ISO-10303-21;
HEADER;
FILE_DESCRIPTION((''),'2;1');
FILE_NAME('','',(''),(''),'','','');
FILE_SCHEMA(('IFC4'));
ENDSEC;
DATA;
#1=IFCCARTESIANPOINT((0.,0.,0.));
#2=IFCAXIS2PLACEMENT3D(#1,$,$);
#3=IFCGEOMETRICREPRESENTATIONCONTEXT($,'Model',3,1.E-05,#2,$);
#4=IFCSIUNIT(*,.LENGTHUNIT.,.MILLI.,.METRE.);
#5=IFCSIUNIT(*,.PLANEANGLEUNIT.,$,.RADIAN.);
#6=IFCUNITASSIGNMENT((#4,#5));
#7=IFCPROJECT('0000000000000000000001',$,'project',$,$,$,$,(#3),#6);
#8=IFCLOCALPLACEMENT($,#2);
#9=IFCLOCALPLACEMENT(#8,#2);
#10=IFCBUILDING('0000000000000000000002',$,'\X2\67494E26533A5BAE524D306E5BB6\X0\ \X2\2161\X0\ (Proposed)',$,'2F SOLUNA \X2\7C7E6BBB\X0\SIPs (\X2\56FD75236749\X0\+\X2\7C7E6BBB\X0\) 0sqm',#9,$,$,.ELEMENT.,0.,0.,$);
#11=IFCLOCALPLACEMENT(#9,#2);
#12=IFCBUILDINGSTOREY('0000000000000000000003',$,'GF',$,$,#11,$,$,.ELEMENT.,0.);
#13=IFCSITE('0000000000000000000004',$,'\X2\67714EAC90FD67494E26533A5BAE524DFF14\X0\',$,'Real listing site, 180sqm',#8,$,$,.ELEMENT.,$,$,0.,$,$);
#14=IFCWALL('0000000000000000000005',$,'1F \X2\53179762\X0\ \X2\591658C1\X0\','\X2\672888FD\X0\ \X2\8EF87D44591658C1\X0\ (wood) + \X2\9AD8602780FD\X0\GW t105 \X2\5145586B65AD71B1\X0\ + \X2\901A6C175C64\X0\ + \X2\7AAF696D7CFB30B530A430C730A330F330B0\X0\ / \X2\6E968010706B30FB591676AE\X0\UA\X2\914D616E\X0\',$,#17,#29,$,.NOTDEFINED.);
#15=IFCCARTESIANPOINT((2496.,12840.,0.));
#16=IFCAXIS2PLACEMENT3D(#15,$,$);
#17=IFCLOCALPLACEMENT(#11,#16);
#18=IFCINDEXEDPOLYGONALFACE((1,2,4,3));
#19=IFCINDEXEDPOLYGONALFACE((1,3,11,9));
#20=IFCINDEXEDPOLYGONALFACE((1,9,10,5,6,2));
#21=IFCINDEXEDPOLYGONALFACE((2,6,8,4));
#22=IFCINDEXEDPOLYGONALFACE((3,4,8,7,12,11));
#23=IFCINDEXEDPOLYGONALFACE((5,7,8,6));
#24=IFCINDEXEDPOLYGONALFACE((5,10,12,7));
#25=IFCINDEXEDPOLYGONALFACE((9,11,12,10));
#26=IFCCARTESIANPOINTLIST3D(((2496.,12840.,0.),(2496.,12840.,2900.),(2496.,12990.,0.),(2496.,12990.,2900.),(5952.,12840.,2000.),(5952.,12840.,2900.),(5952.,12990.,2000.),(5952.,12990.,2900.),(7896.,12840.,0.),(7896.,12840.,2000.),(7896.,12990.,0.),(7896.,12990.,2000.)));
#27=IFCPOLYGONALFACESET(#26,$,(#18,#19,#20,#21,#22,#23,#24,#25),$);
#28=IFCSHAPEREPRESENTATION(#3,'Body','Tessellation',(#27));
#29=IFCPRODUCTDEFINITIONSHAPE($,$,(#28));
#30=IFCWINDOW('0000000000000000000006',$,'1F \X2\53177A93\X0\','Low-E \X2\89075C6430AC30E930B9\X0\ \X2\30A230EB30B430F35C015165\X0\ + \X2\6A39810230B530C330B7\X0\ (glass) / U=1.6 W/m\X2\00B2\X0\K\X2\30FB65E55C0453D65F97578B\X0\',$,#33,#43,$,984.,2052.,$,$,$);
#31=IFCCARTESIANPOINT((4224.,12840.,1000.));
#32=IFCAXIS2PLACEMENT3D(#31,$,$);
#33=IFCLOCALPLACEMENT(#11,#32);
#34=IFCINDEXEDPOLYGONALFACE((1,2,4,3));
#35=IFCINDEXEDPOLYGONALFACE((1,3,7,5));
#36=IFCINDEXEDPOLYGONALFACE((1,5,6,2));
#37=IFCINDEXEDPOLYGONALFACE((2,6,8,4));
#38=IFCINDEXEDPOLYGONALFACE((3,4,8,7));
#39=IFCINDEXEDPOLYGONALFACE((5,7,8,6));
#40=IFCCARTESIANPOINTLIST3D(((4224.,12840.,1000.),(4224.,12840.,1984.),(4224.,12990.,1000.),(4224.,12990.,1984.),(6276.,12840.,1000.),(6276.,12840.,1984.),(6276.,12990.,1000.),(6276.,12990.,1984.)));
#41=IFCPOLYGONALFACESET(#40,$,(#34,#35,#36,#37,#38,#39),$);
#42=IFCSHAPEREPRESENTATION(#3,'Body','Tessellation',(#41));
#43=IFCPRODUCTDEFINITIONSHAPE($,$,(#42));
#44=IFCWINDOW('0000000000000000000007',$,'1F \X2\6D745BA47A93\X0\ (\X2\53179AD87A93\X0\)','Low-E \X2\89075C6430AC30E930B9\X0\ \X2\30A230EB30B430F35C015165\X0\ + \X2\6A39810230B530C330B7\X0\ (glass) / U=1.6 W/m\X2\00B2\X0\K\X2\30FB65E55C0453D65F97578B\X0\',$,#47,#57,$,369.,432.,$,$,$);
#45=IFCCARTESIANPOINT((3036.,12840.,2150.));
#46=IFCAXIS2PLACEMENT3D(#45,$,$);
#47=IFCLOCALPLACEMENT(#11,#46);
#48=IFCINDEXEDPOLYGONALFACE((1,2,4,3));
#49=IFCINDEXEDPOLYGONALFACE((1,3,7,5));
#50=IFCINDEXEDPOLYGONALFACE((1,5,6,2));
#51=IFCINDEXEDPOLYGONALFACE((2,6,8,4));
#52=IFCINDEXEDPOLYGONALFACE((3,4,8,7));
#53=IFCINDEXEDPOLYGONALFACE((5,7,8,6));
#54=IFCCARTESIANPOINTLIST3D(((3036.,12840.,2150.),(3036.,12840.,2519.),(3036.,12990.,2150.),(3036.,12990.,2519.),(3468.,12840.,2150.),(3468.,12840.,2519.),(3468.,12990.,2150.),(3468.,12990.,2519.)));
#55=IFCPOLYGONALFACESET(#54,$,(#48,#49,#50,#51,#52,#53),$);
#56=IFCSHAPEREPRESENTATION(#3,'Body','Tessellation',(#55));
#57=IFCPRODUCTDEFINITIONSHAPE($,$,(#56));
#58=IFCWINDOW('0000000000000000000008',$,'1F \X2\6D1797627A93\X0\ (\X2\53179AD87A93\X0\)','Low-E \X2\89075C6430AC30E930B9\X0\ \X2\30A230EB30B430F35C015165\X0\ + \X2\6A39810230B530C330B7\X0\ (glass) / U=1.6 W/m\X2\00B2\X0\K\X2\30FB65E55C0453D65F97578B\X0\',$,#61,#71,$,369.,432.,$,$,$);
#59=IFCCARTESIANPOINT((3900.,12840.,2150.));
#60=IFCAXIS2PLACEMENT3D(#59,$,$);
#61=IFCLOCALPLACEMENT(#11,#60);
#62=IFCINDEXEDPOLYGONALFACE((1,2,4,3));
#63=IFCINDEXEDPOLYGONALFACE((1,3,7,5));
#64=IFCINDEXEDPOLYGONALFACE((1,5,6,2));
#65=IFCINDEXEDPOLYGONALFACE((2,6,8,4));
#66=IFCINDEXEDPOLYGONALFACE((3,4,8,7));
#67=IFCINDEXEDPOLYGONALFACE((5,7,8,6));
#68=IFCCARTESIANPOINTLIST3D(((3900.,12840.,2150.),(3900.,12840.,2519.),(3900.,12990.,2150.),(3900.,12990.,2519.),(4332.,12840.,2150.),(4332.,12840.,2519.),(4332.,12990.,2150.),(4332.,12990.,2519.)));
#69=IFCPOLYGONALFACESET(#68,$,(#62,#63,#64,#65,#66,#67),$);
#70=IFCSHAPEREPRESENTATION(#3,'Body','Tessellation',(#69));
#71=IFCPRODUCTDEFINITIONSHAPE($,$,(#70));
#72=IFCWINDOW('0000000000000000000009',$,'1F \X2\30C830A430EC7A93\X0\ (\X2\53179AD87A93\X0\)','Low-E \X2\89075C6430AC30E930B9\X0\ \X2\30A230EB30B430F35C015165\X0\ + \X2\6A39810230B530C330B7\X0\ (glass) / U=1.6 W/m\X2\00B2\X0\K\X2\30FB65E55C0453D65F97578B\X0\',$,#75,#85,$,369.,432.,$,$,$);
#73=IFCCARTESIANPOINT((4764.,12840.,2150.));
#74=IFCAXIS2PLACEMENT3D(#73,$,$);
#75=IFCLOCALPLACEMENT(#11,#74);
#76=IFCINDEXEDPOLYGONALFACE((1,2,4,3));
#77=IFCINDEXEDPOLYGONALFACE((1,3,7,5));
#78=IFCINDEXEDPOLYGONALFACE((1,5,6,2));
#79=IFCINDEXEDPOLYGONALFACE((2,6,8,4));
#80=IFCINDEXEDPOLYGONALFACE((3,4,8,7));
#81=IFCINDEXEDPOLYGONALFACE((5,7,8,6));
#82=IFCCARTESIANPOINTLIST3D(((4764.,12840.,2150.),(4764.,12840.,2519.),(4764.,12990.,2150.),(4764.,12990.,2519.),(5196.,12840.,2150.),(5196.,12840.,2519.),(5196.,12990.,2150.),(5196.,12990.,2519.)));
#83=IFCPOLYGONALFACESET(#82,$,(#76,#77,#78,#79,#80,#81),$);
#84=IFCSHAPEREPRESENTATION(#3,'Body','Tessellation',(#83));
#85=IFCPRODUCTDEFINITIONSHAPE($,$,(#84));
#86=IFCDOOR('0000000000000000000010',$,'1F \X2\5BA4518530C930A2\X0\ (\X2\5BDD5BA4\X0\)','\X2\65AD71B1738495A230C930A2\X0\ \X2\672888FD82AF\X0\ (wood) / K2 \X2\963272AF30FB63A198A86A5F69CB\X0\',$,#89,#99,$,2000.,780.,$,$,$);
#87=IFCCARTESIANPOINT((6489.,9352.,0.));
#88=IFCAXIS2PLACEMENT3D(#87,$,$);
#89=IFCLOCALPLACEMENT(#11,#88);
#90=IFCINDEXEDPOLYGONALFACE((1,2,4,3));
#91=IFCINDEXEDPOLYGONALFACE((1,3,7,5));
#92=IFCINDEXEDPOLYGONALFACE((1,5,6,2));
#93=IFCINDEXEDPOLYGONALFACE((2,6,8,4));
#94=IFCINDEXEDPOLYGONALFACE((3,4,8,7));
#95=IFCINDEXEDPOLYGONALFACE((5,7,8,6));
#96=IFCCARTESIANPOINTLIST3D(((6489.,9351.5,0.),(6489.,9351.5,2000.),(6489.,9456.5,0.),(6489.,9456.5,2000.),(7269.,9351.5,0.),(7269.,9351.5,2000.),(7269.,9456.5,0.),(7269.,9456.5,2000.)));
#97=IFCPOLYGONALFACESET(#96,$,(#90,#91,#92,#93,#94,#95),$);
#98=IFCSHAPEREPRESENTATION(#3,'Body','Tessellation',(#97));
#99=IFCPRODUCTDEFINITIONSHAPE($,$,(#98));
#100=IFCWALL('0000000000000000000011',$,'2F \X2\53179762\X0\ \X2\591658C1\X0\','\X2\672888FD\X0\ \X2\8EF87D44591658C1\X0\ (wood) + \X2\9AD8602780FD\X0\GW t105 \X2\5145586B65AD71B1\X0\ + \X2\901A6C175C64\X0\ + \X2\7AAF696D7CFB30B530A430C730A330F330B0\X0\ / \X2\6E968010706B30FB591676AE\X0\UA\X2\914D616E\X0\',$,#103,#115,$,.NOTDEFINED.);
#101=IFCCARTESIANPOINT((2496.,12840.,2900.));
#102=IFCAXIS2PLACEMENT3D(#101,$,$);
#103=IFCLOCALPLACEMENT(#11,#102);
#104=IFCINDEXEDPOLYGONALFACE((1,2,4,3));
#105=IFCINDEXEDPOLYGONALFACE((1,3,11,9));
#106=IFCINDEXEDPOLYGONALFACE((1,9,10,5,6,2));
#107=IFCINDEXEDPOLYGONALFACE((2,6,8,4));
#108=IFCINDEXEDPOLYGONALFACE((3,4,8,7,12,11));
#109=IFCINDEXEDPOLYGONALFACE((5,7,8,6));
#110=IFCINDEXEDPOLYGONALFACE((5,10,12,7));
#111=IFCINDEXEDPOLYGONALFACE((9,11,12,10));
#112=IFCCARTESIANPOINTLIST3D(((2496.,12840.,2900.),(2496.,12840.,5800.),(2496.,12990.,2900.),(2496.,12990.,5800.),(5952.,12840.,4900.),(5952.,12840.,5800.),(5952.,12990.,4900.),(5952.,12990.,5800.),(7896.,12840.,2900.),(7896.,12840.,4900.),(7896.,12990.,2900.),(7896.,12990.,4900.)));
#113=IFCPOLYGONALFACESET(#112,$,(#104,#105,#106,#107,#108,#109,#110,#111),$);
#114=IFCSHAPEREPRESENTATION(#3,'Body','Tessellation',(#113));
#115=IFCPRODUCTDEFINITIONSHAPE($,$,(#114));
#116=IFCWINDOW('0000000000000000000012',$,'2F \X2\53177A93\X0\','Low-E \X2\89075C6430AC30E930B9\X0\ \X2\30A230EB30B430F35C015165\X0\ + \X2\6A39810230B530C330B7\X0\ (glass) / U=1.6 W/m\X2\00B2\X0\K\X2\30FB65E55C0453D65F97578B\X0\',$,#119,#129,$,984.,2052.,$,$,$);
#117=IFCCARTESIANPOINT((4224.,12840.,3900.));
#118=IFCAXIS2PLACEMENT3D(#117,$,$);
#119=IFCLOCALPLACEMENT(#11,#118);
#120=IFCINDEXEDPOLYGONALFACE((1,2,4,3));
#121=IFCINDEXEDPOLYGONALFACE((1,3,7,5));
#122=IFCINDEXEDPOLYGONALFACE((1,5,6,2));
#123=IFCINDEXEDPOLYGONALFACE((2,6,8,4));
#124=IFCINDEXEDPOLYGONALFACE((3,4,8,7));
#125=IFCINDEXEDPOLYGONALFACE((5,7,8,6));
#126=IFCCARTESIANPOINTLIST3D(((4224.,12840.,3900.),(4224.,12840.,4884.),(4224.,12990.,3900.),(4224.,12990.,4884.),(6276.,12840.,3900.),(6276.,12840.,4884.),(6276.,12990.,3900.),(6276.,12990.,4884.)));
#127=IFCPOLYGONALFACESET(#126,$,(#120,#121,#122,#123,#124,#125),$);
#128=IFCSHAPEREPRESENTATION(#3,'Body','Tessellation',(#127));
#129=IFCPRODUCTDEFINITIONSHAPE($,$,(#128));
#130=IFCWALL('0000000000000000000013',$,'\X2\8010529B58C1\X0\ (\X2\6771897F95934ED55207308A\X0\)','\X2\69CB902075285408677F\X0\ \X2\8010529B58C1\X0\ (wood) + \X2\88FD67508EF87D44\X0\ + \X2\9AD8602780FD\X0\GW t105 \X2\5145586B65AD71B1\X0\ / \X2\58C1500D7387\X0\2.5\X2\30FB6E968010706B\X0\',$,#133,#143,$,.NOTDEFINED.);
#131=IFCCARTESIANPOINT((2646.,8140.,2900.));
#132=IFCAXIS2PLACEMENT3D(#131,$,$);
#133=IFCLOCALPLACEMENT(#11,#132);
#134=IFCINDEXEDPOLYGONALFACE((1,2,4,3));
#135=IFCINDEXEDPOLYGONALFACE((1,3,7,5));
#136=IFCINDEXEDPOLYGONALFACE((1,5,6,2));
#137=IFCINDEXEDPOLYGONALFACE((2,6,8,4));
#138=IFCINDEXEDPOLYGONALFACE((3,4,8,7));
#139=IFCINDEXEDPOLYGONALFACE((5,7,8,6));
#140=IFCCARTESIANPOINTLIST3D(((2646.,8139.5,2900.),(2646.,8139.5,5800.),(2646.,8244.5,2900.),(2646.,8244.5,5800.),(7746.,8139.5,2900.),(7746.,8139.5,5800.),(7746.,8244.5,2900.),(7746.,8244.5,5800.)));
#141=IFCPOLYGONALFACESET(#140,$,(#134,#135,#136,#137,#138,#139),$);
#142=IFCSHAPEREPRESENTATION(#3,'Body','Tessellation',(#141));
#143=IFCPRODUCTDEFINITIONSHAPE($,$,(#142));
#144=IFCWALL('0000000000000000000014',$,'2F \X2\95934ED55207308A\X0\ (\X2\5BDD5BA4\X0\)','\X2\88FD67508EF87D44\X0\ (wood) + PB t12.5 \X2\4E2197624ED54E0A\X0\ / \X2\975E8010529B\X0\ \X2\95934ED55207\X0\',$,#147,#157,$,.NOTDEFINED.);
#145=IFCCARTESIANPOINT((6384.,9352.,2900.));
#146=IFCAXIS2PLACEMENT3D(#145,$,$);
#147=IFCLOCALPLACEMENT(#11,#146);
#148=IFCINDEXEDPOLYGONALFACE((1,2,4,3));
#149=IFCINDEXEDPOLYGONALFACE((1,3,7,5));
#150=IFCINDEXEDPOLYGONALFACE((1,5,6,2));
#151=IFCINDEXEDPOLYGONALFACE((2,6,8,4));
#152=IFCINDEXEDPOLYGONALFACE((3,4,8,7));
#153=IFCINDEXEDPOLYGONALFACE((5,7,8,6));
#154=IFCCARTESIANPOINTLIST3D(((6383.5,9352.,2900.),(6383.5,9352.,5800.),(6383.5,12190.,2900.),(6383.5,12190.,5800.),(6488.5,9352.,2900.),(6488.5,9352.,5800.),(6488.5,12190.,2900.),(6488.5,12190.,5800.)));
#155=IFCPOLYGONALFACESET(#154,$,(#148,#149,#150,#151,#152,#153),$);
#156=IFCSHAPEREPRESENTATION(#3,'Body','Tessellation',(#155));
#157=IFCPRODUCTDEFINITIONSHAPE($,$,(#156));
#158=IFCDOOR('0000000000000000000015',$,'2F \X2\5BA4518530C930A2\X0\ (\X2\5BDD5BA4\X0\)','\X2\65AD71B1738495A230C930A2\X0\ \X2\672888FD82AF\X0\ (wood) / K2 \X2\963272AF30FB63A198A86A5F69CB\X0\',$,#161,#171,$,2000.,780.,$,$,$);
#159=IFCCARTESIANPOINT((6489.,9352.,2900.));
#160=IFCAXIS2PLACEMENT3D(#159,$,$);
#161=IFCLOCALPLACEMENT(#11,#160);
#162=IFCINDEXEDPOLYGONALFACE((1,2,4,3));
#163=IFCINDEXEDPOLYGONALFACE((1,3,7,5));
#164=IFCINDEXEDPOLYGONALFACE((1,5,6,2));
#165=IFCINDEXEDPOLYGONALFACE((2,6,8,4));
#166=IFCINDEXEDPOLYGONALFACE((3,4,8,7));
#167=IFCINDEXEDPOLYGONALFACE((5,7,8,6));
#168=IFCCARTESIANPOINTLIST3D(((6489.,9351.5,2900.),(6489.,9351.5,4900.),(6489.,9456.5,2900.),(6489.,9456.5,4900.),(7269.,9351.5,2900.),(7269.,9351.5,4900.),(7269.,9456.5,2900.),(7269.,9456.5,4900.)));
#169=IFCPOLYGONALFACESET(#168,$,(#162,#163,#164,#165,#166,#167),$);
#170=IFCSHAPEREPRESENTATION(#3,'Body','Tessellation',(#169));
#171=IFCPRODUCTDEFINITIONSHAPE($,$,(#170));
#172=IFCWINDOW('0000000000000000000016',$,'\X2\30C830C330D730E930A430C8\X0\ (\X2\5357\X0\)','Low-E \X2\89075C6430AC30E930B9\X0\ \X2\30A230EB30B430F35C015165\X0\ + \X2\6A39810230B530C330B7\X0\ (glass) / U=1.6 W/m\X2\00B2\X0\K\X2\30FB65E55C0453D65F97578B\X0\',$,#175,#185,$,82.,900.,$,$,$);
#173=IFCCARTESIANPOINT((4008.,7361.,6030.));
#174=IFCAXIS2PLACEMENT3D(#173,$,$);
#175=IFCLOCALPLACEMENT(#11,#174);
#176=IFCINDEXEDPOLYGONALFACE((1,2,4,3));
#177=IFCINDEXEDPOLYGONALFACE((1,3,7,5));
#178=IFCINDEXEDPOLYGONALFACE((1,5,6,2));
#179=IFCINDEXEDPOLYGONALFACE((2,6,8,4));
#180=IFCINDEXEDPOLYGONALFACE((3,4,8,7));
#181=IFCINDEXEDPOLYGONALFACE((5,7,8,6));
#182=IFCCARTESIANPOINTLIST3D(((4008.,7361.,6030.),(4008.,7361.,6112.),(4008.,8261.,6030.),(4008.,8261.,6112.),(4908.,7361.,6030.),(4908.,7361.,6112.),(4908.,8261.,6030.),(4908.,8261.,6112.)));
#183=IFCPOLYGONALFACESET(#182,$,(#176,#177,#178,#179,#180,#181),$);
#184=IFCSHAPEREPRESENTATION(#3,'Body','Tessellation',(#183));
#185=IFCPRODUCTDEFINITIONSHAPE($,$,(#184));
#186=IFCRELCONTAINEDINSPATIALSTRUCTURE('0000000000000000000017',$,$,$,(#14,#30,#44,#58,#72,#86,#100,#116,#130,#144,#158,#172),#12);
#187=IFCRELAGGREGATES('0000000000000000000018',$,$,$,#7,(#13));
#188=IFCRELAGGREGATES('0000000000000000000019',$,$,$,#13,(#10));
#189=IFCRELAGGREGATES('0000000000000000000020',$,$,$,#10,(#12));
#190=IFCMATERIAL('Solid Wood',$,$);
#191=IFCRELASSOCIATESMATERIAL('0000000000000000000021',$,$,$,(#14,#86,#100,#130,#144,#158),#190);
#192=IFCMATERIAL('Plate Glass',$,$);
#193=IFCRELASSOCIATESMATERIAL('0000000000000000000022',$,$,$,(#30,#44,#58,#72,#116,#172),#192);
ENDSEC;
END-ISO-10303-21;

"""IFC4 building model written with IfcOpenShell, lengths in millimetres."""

from ifc_helpers import new_model, si_unit, frame, frame_2d, origin, place, context, project, spatial, rectangle, extrude, material, element, fill, save


model = new_model("IFC4")

# Units and contexts
model_context = context("Model", 3, precision=1e-05, world=origin())
ifc_project = project(units=[si_unit("LENGTHUNIT", "METRE", prefix="MILLI"), si_unit("PLANEANGLEUNIT", "RADIAN")], contexts=[model_context])

# Site, building, storey
site_placement = place(None, origin())
site = spatial("IfcSite", under=ifc_project, at=site_placement, Name="東京都杉並区宮前４", ObjectType="Real listing site, 180sqm", CompositionType="ELEMENT", RefElevation=0.0)
building_placement = place(site_placement, origin())
building = spatial("IfcBuilding", under=site, at=building_placement, Name="杉並区宮前の家 Ⅱ (Proposed)", ObjectType="2F SOLUNA 籾殻SIPs (国産杉+籾殻) 0sqm", CompositionType="ELEMENT", ElevationOfRefHeight=0.0, ElevationOfTerrain=0.0)
storey_placement = place(building_placement, origin())
storey = spatial("IfcBuildingStorey", under=building, at=storey_placement, Name="GF", CompositionType="ELEMENT", Elevation=0.0)

# Wall, openings, windows
ifc_material_1 = material(Name="Solid Wood")
wall_1_placement = place(storey_placement, frame((2496.0, 12840.0, 0.0)))
wall_1 = element("IfcWall", 1, at=wall_1_placement, inside=storey, material=ifc_material_1, Name="1F 北面 外壁", Description="木製 軸組外壁 (wood) + 高性能GW t105 充填断熱 + 通気層 + 窯業系サイディング / 準耐火・外皮UA配慮", PredefinedType="NOTDEFINED", context=model_context, shape_type="SweptSolid", body=[
    extrude(rectangle(XDim=5400.0, YDim=150.0, at=frame_2d((2700.0, 75.0))), frame((2496.0, 12840.0, 0.0)), (0.0, 0.0, 1.0), 2900.0),
])
opening_1_placement = place(storey_placement, frame((4224.0, 12840.0, 1000.0)))
opening_1 = element("IfcOpeningElement", 2, at=opening_1_placement, cuts=wall_1, PredefinedType="NOTDEFINED", context=model_context, shape_type="SweptSolid", body=[
    extrude(rectangle(XDim=2052.0, YDim=150.0, at=frame_2d((1026.0, 75.0))), frame((4224.0, 12840.0, 1000.0)), (0.0, 0.0, 1.0), 984.0),
])
opening_2_placement = place(storey_placement, frame((3036.0, 12840.0, 2150.0)))
opening_2 = element("IfcOpeningElement", 3, at=opening_2_placement, cuts=wall_1, PredefinedType="NOTDEFINED", context=model_context, shape_type="SweptSolid", body=[
    extrude(rectangle(XDim=432.0, YDim=150.0, at=frame_2d((216.0, 75.0))), frame((3036.0, 12840.0, 2150.0)), (0.0, 0.0, 1.0), 369.0),
])
opening_3_placement = place(storey_placement, frame((3900.0, 12840.0, 2150.0)))
opening_3 = element("IfcOpeningElement", 4, at=opening_3_placement, cuts=wall_1, PredefinedType="NOTDEFINED", context=model_context, shape_type="SweptSolid", body=[
    extrude(rectangle(XDim=432.0, YDim=150.0, at=frame_2d((216.0, 75.0))), frame((3900.0, 12840.0, 2150.0)), (0.0, 0.0, 1.0), 369.0),
])
opening_4_placement = place(storey_placement, frame((4764.0, 12840.0, 2150.0)))
opening_4 = element("IfcOpeningElement", 5, at=opening_4_placement, cuts=wall_1, PredefinedType="NOTDEFINED", context=model_context, shape_type="SweptSolid", body=[
    extrude(rectangle(XDim=432.0, YDim=150.0, at=frame_2d((216.0, 75.0))), frame((4764.0, 12840.0, 2150.0)), (0.0, 0.0, 1.0), 369.0),
])
ifc_material_2 = material(Name="Plate Glass")
window_1_placement = place(storey_placement, frame((4224.0, 12840.0, 1000.0)))
window_1 = element("IfcWindow", 6, at=window_1_placement, inside=storey, material=ifc_material_2, Name="1F 北窓", Description="Low-E 複層ガラス アルゴン封入 + 樹脂サッシ (glass) / U=1.6 W/m²K・日射取得型", OverallHeight=984.0, OverallWidth=2052.0, context=model_context, shape_type="SweptSolid", body=[
    extrude(rectangle(XDim=2052.0, YDim=150.0, at=frame_2d((1026.0, 75.0))), frame((4224.0, 12840.0, 1000.0)), (0.0, 0.0, 1.0), 984.0),
])
fill(opening_1, window_1)
window_2_placement = place(storey_placement, frame((3036.0, 12840.0, 2150.0)))
window_2 = element("IfcWindow", 7, at=window_2_placement, inside=storey, material=ifc_material_2, Name="1F 浴室窓 (北高窓)", Description="Low-E 複層ガラス アルゴン封入 + 樹脂サッシ (glass) / U=1.6 W/m²K・日射取得型", OverallHeight=369.0, OverallWidth=432.0, context=model_context, shape_type="SweptSolid", body=[
    extrude(rectangle(XDim=432.0, YDim=150.0, at=frame_2d((216.0, 75.0))), frame((3036.0, 12840.0, 2150.0)), (0.0, 0.0, 1.0), 369.0),
])
fill(opening_2, window_2)
window_3_placement = place(storey_placement, frame((3900.0, 12840.0, 2150.0)))
window_3 = element("IfcWindow", 8, at=window_3_placement, inside=storey, material=ifc_material_2, Name="1F 洗面窓 (北高窓)", Description="Low-E 複層ガラス アルゴン封入 + 樹脂サッシ (glass) / U=1.6 W/m²K・日射取得型", OverallHeight=369.0, OverallWidth=432.0, context=model_context, shape_type="SweptSolid", body=[
    extrude(rectangle(XDim=432.0, YDim=150.0, at=frame_2d((216.0, 75.0))), frame((3900.0, 12840.0, 2150.0)), (0.0, 0.0, 1.0), 369.0),
])
fill(opening_3, window_3)
window_4_placement = place(storey_placement, frame((4764.0, 12840.0, 2150.0)))
window_4 = element("IfcWindow", 9, at=window_4_placement, inside=storey, material=ifc_material_2, Name="1F トイレ窓 (北高窓)", Description="Low-E 複層ガラス アルゴン封入 + 樹脂サッシ (glass) / U=1.6 W/m²K・日射取得型", OverallHeight=369.0, OverallWidth=432.0, context=model_context, shape_type="SweptSolid", body=[
    extrude(rectangle(XDim=432.0, YDim=150.0, at=frame_2d((216.0, 75.0))), frame((4764.0, 12840.0, 2150.0)), (0.0, 0.0, 1.0), 369.0),
])
fill(opening_4, window_4)

# Door
door_1_placement = place(storey_placement, frame((6489.0, 9352.0, 0.0)))
element("IfcDoor", 10, at=door_1_placement, inside=storey, material=ifc_material_1, Name="1F 室内ドア (寝室)", Description="断熱玄関ドア 木製芯 (wood) / K2 防犯・採風機構", OverallHeight=2000.0, OverallWidth=780.0, context=model_context, shape_type="SweptSolid", body=[
    extrude(rectangle(XDim=780.0, YDim=105.0, at=frame_2d((390.0, 52.0))), frame((6489.0, 9352.0, 0.0)), (0.0, 0.0, 1.0), 2000.0),
])

# Wall, opening, window
wall_2_placement = place(storey_placement, frame((2496.0, 12840.0, 2900.0)))
wall_2 = element("IfcWall", 11, at=wall_2_placement, inside=storey, material=ifc_material_1, Name="2F 北面 外壁", Description="木製 軸組外壁 (wood) + 高性能GW t105 充填断熱 + 通気層 + 窯業系サイディング / 準耐火・外皮UA配慮", PredefinedType="NOTDEFINED", context=model_context, shape_type="SweptSolid", body=[
    extrude(rectangle(XDim=5400.0, YDim=150.0, at=frame_2d((2700.0, 75.0))), frame((2496.0, 12840.0, 2900.0)), (0.0, 0.0, 1.0), 2900.0),
])
opening_5_placement = place(storey_placement, frame((4224.0, 12840.0, 3900.0)))
opening_5 = element("IfcOpeningElement", 12, at=opening_5_placement, cuts=wall_2, PredefinedType="NOTDEFINED", context=model_context, shape_type="SweptSolid", body=[
    extrude(rectangle(XDim=2052.0, YDim=150.0, at=frame_2d((1026.0, 75.0))), frame((4224.0, 12840.0, 3900.0)), (0.0, 0.0, 1.0), 984.0),
])
window_5_placement = place(storey_placement, frame((4224.0, 12840.0, 3900.0)))
window_5 = element("IfcWindow", 13, at=window_5_placement, inside=storey, material=ifc_material_2, Name="2F 北窓", Description="Low-E 複層ガラス アルゴン封入 + 樹脂サッシ (glass) / U=1.6 W/m²K・日射取得型", OverallHeight=984.0, OverallWidth=2052.0, context=model_context, shape_type="SweptSolid", body=[
    extrude(rectangle(XDim=2052.0, YDim=150.0, at=frame_2d((1026.0, 75.0))), frame((4224.0, 12840.0, 3900.0)), (0.0, 0.0, 1.0), 984.0),
])
fill(opening_5, window_5)

# Walls
wall_3_placement = place(storey_placement, frame((2646.0, 8140.0, 2900.0)))
element("IfcWall", 14, at=wall_3_placement, inside=storey, material=ifc_material_1, Name="耐力壁 (東西間仕切り)", Description="構造用合板 耐力壁 (wood) + 製材軸組 + 高性能GW t105 充填断熱 / 壁倍率2.5・準耐火", PredefinedType="NOTDEFINED", context=model_context, shape_type="SweptSolid", body=[
    extrude(rectangle(XDim=5100.0, YDim=105.0, at=frame_2d((2550.0, 52.0))), frame((2646.0, 8140.0, 2900.0)), (0.0, 0.0, 1.0), 2900.0),
])
wall_4_placement = place(storey_placement, frame((6384.0, 9352.0, 2900.0)))
element("IfcWall", 15, at=wall_4_placement, inside=storey, material=ifc_material_1, Name="2F 間仕切り (寝室)", Description="製材軸組 (wood) + PB t12.5 両面仕上 / 非耐力 間仕切", PredefinedType="NOTDEFINED", context=model_context, shape_type="SweptSolid", body=[
    extrude(rectangle(XDim=105.0, YDim=2838.0, at=frame_2d((52.0, 1419.0))), frame((6384.0, 9352.0, 2900.0)), (0.0, 0.0, 1.0), 2900.0),
])

# Door
door_2_placement = place(storey_placement, frame((6489.0, 9352.0, 2900.0)))
element("IfcDoor", 16, at=door_2_placement, inside=storey, material=ifc_material_1, Name="2F 室内ドア (寝室)", Description="断熱玄関ドア 木製芯 (wood) / K2 防犯・採風機構", OverallHeight=2000.0, OverallWidth=780.0, context=model_context, shape_type="SweptSolid", body=[
    extrude(rectangle(XDim=780.0, YDim=105.0, at=frame_2d((390.0, 52.0))), frame((6489.0, 9352.0, 2900.0)), (0.0, 0.0, 1.0), 2000.0),
])

# Window
window_6_placement = place(storey_placement, frame((4008.0, 7361.0, 6030.0)))
element("IfcWindow", 17, at=window_6_placement, inside=storey, material=ifc_material_2, Name="トップライト (南)", Description="Low-E 複層ガラス アルゴン封入 + 樹脂サッシ (glass) / U=1.6 W/m²K・日射取得型", OverallHeight=82.0, OverallWidth=900.0, context=model_context, shape_type="SweptSolid", body=[
    extrude(rectangle(XDim=900.0, YDim=900.0, at=frame_2d((450.0, 450.0))), frame((4008.0, 7361.0, 6030.0)), (0.0, 0.0, 1.0), 82.0),
])

save(model, "model.ifc")
